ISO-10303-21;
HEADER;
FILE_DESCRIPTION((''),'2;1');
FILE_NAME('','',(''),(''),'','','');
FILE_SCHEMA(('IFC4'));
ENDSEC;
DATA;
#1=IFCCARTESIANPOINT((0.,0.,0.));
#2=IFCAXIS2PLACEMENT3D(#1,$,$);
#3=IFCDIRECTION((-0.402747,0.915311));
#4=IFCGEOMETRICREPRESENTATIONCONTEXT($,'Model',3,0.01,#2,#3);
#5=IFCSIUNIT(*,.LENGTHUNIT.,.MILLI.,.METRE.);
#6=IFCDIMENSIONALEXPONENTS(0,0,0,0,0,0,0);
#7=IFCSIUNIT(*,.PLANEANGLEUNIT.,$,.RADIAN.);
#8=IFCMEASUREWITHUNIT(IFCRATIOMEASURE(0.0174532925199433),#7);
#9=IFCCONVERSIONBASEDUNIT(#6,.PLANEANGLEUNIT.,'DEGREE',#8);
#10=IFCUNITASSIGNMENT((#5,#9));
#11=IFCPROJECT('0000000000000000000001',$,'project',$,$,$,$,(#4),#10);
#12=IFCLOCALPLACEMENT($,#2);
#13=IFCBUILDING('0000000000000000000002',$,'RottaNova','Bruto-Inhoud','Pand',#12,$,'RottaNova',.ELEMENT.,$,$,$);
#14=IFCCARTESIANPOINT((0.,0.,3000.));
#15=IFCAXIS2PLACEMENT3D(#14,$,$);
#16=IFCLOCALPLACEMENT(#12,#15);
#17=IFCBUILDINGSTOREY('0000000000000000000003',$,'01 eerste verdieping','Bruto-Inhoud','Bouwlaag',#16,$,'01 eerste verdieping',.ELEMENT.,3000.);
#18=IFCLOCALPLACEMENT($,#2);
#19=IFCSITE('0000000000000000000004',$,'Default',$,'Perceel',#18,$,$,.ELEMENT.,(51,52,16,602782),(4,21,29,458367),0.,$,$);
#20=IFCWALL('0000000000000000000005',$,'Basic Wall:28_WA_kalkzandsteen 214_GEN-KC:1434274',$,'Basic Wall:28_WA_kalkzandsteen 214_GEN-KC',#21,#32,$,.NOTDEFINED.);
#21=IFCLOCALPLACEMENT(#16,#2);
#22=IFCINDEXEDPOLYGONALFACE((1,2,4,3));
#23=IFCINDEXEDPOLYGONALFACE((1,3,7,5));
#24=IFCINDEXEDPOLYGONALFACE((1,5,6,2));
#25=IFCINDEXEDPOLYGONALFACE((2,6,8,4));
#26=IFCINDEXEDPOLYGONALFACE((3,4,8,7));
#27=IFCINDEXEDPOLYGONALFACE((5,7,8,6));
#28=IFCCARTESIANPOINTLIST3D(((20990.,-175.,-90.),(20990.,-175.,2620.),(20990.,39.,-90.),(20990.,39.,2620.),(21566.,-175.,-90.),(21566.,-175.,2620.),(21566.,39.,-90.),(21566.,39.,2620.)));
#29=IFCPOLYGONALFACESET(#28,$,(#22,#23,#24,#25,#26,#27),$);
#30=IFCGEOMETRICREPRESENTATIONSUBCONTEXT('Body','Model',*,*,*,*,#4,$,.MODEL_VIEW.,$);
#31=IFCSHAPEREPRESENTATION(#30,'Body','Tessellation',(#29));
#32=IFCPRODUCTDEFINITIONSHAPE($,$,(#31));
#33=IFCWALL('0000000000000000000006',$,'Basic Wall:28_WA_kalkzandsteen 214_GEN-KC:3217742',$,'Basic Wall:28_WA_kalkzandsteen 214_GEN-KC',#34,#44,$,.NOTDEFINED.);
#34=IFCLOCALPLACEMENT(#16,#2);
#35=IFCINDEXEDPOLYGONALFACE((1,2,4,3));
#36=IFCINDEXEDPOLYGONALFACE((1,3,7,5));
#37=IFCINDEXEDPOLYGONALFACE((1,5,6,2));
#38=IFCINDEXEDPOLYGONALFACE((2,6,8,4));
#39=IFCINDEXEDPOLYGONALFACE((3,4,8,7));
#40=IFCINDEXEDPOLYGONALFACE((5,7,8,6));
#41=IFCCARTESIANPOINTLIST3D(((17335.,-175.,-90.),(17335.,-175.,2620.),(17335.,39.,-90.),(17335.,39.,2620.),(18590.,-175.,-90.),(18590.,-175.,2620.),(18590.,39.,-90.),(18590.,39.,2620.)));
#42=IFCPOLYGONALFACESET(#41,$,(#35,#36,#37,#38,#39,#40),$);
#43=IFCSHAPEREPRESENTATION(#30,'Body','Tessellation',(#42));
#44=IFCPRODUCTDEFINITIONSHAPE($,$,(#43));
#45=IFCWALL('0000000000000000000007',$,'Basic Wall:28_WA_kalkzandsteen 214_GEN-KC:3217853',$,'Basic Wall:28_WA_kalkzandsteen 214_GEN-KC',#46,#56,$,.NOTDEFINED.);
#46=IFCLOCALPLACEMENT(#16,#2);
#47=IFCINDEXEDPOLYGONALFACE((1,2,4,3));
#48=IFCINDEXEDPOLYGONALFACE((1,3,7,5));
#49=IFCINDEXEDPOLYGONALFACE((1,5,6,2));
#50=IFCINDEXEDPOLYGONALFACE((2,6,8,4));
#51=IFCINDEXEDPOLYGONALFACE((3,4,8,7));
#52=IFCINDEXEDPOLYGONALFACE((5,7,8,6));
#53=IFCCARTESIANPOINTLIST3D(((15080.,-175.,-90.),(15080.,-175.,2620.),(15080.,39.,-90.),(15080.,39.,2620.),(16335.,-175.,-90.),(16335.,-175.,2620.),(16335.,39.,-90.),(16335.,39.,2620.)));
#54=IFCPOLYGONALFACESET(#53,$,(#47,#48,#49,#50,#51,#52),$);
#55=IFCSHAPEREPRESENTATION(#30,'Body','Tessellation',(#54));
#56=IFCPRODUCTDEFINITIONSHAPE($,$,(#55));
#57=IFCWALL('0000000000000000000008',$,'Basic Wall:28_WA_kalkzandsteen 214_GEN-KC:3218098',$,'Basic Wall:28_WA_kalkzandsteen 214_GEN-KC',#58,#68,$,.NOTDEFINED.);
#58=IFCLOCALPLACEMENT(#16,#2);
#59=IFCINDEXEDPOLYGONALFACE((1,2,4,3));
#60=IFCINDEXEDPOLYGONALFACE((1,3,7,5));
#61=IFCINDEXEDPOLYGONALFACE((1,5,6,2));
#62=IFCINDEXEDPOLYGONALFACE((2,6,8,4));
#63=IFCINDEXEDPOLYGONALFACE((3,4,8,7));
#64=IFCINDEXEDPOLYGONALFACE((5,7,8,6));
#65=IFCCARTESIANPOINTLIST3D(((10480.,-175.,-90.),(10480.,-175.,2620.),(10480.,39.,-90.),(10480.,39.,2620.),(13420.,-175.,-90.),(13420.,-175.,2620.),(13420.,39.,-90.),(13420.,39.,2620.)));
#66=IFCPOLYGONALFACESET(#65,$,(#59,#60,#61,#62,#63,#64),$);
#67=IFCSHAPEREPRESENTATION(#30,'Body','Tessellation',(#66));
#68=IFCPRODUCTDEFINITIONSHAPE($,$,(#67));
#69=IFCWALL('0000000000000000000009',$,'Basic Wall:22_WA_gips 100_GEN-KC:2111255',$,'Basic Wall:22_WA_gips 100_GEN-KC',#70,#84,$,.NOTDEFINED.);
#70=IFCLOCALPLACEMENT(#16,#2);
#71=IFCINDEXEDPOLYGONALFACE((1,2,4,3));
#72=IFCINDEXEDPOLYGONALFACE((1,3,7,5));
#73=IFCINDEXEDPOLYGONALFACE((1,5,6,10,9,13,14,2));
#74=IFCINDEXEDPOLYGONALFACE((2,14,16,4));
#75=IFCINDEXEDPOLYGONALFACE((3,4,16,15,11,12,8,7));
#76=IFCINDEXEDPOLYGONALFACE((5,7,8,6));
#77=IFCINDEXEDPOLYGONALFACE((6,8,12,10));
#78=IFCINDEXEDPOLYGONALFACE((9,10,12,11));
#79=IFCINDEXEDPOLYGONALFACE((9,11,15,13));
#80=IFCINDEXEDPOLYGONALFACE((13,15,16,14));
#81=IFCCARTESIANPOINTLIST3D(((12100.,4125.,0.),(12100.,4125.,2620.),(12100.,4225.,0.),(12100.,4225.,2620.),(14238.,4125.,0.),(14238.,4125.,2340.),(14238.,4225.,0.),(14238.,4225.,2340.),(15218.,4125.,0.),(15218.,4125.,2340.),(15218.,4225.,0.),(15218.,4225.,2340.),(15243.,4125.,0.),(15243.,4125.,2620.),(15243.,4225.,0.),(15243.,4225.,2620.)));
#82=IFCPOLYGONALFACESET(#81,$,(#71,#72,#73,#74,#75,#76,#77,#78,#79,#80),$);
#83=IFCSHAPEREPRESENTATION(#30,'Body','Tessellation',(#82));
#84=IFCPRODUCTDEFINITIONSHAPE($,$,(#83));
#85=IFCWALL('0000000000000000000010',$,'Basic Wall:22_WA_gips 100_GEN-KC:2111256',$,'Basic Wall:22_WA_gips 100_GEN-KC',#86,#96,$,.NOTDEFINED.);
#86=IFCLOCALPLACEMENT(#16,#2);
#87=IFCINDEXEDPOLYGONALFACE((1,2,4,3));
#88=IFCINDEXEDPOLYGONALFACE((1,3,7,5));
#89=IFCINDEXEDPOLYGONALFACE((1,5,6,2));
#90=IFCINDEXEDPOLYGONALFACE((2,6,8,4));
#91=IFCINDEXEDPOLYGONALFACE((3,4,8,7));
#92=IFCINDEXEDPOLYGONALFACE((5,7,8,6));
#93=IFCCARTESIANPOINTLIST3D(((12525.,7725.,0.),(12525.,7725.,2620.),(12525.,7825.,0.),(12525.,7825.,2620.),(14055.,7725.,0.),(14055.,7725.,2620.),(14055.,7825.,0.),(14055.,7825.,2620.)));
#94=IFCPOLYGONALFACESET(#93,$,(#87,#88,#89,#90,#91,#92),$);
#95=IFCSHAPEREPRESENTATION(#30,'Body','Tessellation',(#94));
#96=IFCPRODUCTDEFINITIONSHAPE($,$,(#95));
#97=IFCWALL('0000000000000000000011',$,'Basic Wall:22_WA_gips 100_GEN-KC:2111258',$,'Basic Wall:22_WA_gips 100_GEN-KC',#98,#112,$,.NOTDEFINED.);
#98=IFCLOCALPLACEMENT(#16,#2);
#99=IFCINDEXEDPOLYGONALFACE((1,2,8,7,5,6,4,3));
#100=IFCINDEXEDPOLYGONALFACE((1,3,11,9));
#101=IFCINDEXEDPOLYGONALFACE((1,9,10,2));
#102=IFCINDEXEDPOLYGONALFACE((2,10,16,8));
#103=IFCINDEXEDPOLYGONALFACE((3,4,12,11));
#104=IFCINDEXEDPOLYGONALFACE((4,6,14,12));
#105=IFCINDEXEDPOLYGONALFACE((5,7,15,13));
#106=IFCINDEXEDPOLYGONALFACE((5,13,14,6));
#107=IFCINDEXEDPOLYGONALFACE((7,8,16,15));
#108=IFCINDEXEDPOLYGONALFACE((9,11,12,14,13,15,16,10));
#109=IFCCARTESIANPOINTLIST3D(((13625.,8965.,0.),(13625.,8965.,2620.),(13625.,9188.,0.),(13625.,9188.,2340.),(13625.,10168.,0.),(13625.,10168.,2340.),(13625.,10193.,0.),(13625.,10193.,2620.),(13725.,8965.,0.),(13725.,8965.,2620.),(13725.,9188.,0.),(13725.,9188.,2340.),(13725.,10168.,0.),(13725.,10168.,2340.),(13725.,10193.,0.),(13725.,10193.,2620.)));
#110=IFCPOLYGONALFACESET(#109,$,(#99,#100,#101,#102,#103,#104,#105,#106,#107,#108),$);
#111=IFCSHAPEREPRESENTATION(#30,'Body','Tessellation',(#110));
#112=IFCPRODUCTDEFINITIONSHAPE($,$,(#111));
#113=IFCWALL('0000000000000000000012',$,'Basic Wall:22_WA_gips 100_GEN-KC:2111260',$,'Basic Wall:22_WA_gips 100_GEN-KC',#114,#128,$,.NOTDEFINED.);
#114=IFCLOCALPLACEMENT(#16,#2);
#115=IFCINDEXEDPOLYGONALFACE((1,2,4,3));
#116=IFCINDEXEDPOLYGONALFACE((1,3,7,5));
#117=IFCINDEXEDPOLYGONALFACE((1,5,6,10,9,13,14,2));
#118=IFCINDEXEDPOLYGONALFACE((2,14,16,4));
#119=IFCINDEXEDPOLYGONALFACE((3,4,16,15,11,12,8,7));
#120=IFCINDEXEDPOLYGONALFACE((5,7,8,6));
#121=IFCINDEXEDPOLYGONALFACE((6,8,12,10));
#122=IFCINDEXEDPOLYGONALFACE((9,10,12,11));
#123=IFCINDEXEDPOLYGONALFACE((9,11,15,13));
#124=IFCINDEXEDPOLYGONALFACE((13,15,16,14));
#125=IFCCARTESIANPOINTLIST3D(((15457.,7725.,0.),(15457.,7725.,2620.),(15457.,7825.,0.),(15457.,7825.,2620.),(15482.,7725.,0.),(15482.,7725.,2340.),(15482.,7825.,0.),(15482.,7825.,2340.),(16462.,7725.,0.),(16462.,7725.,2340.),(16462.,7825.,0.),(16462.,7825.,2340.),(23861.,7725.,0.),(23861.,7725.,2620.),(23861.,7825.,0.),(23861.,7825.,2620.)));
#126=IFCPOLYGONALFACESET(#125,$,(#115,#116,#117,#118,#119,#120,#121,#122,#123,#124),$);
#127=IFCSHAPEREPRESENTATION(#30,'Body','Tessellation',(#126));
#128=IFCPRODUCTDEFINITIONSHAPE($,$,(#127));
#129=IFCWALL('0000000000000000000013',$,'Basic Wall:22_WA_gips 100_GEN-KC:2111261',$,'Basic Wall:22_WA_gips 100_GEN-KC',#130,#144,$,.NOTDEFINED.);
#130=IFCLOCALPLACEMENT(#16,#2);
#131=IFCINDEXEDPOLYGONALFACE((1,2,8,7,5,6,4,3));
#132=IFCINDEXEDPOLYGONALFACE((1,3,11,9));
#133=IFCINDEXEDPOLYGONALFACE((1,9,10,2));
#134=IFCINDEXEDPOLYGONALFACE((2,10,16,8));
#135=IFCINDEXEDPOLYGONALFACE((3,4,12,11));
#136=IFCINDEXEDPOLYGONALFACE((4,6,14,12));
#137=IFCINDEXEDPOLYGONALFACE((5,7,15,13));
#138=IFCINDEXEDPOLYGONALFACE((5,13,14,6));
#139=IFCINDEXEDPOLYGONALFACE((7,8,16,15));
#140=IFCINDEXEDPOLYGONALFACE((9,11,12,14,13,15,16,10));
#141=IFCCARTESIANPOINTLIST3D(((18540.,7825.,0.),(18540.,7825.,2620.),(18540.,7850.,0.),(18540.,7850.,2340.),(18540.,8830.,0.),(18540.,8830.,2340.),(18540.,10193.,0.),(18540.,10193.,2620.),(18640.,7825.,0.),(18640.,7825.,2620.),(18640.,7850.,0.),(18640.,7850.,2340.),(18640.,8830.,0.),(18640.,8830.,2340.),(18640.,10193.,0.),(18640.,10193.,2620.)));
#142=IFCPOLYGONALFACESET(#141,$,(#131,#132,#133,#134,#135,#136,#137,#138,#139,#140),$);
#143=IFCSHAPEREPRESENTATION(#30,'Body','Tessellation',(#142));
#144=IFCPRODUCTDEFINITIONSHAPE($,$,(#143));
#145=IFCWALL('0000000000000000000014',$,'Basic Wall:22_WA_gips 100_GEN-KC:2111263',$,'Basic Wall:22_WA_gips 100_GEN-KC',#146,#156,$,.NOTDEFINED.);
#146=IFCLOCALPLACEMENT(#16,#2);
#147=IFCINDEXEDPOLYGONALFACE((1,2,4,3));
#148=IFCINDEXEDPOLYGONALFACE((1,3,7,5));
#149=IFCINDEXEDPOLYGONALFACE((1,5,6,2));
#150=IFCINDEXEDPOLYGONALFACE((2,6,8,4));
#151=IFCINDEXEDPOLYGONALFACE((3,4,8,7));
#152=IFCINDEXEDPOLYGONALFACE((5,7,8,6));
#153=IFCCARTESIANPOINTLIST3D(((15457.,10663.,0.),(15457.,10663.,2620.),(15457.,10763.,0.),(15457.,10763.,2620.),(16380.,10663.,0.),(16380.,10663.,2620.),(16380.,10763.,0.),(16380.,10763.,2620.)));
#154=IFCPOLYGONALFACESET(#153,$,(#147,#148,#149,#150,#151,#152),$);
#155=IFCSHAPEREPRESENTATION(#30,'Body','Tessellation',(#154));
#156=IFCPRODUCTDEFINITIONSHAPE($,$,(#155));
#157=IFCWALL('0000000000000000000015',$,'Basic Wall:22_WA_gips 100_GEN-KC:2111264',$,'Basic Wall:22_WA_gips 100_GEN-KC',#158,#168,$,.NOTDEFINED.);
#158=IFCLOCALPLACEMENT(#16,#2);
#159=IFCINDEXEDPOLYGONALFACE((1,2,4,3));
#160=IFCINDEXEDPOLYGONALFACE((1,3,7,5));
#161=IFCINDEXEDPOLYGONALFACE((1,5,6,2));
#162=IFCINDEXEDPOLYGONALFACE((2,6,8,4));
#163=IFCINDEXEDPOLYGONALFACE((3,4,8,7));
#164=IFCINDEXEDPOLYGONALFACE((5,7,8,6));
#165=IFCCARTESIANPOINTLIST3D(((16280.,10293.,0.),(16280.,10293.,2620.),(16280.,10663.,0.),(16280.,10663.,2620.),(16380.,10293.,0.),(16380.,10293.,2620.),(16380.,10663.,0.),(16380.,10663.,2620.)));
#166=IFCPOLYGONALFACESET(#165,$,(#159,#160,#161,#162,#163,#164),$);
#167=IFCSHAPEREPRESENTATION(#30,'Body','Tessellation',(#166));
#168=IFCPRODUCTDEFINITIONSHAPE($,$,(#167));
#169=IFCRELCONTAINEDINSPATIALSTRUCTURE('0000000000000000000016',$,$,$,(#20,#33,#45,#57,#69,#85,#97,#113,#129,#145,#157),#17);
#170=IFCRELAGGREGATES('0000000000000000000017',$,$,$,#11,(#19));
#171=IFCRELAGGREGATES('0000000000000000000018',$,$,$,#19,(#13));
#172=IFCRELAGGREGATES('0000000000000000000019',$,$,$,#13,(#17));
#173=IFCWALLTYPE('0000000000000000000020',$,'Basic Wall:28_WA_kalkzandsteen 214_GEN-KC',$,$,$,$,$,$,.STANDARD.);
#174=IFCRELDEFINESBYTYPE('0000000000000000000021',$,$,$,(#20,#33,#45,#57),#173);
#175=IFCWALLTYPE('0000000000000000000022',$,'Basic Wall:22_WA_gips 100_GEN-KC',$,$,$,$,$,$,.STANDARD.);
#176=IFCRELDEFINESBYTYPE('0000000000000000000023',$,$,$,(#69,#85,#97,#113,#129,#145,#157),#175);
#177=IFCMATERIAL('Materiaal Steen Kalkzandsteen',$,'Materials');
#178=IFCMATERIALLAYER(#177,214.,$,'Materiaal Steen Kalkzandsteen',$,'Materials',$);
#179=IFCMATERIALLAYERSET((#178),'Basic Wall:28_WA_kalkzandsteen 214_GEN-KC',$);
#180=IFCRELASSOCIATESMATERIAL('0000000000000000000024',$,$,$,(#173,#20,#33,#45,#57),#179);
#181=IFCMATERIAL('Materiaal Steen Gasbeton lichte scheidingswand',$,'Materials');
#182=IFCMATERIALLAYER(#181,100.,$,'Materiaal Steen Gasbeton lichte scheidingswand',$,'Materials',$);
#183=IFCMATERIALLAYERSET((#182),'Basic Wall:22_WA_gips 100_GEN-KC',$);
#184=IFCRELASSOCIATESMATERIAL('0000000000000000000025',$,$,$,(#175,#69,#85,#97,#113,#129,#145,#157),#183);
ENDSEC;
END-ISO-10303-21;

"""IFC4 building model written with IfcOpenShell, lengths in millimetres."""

from ifc_helpers import new_model, entity, si_unit, converted_unit, direction, frame, frame_2d, origin, place, context, subcontext, project, spatial, rectangle, extrude, material, layer, layer_set, type_object, element, save


model = new_model("IFC4")

# Units and contexts
model_context = context("Model", 3, precision=0.01, world=origin(), true_north=direction((-0.402747, 0.915311)))
body_context = subcontext(model_context, "Body", "Model", "MODEL_VIEW")
ifc_project = project(units=[si_unit("LENGTHUNIT", "METRE", prefix="MILLI"), converted_unit("PLANEANGLEUNIT", "DEGREE", entity("IfcRatioMeasure", 0.0174532925199433), si_unit("PLANEANGLEUNIT", "RADIAN"), dimensions=[0, 0, 0, 0, 0, 0, 0])], contexts=[model_context])

# Site, building, storey
site_placement = place(None, origin())
site = spatial("IfcSite", under=ifc_project, at=site_placement, Name="Default", ObjectType="Perceel", CompositionType="ELEMENT", RefLatitude=(51, 52, 16, 602782), RefLongitude=(4, 21, 29, 458367), RefElevation=0.0)
building_placement = place(None, origin())
building = spatial("IfcBuilding", under=site, at=building_placement, Name="RottaNova", Description="Bruto-Inhoud", ObjectType="Pand", LongName="RottaNova", CompositionType="ELEMENT")
storey_placement = place(building_placement, frame((0.0, 0.0, 3000.0)))
storey = spatial("IfcBuildingStorey", under=building, at=storey_placement, Name="01 eerste verdieping", Description="Bruto-Inhoud", ObjectType="Bouwlaag", LongName="01 eerste verdieping", CompositionType="ELEMENT", Elevation=3000.0)

# Walls
ifc_material_1 = material(Name="Materiaal Steen Kalkzandsteen", Category="Materials")
ifc_layer_1 = layer(ifc_material_1, 214.0, Name="Materiaal Steen Kalkzandsteen", Category="Materials")
ifc_layer_set_1 = layer_set([ifc_layer_1], Name="Basic Wall:28_WA_kalkzandsteen 214_GEN-KC")
wall_type_1 = type_object("IfcWallType", Name="Basic Wall:28_WA_kalkzandsteen 214_GEN-KC", PredefinedType="STANDARD", material=ifc_layer_set_1)
wall_1_placement = place(storey_placement, frame((21566.0, -68.0, -90.0), z_axis=(0.0, 0.0, 1.0), x_axis=(-1.0, 0.0, 0.0)))
element("IfcWall", 1, at=wall_1_placement, inside=storey, type_object=wall_type_1, material=ifc_layer_set_1, Name="Basic Wall:28_WA_kalkzandsteen 214_GEN-KC:1434274", ObjectType="Basic Wall:28_WA_kalkzandsteen 214_GEN-KC", PredefinedType="NOTDEFINED", context=body_context, shape_type="SweptSolid", body=[
    extrude(rectangle(XDim=576.0, YDim=214.0, at=frame_2d((288.0, 0.0), x_axis=(-1.0, 0.0))), origin(), (0.0, 0.0, 1.0), 2710.0),
])
wall_2_placement = place(storey_placement, frame((18590.0, -68.0, -90.0), z_axis=(0.0, 0.0, 1.0), x_axis=(-1.0, 0.0, 0.0)))
element("IfcWall", 2, at=wall_2_placement, inside=storey, type_object=wall_type_1, material=ifc_layer_set_1, Name="Basic Wall:28_WA_kalkzandsteen 214_GEN-KC:3217742", ObjectType="Basic Wall:28_WA_kalkzandsteen 214_GEN-KC", PredefinedType="NOTDEFINED", context=body_context, shape_type="SweptSolid", body=[
    extrude(rectangle(XDim=1255.0, YDim=214.0, at=frame_2d((627.5, 0.0), x_axis=(-1.0, 0.0))), origin(), (0.0, 0.0, 1.0), 2710.0),
])
wall_3_placement = place(storey_placement, frame((16335.0, -68.0, -90.0), z_axis=(0.0, 0.0, 1.0), x_axis=(-1.0, 0.0, 0.0)))
element("IfcWall", 3, at=wall_3_placement, inside=storey, type_object=wall_type_1, material=ifc_layer_set_1, Name="Basic Wall:28_WA_kalkzandsteen 214_GEN-KC:3217853", ObjectType="Basic Wall:28_WA_kalkzandsteen 214_GEN-KC", PredefinedType="NOTDEFINED", context=body_context, shape_type="SweptSolid", body=[
    extrude(rectangle(XDim=1255.0, YDim=214.0, at=frame_2d((627.5, 0.0), x_axis=(-1.0, 0.0))), origin(), (0.0, 0.0, 1.0), 2710.0),
])
wall_4_placement = place(storey_placement, frame((13420.0, -68.0, -90.0), z_axis=(0.0, 0.0, 1.0), x_axis=(-1.0, 0.0, 0.0)))
element("IfcWall", 4, at=wall_4_placement, inside=storey, type_object=wall_type_1, material=ifc_layer_set_1, Name="Basic Wall:28_WA_kalkzandsteen 214_GEN-KC:3218098", ObjectType="Basic Wall:28_WA_kalkzandsteen 214_GEN-KC", PredefinedType="NOTDEFINED", context=body_context, shape_type="SweptSolid", body=[
    extrude(rectangle(XDim=2940.0, YDim=214.0, at=frame_2d((1470.0, 0.0), x_axis=(-1.0, 0.0))), origin(), (0.0, 0.0, 1.0), 2710.0),
])

# Wall, opening
ifc_material_2 = material(Name="Materiaal Steen Gasbeton lichte scheidingswand", Category="Materials")
ifc_layer_2 = layer(ifc_material_2, 100.0, Name="Materiaal Steen Gasbeton lichte scheidingswand", Category="Materials")
ifc_layer_set_2 = layer_set([ifc_layer_2], Name="Basic Wall:22_WA_gips 100_GEN-KC")
wall_type_2 = type_object("IfcWallType", Name="Basic Wall:22_WA_gips 100_GEN-KC", PredefinedType="STANDARD", material=ifc_layer_set_2)
wall_5_placement = place(storey_placement, frame((15243.0, 4175.0, 0.0), z_axis=(0.0, 0.0, 1.0), x_axis=(-1.0, 0.0, 0.0)))
wall_5 = element("IfcWall", 5, at=wall_5_placement, inside=storey, type_object=wall_type_2, material=ifc_layer_set_2, Name="Basic Wall:22_WA_gips 100_GEN-KC:2111255", ObjectType="Basic Wall:22_WA_gips 100_GEN-KC", PredefinedType="NOTDEFINED", context=body_context, shape_type="SweptSolid", body=[
    extrude(rectangle(XDim=3143.0, YDim=100.0, at=frame_2d((1571.5, 0.0), x_axis=(-1.0, 0.0))), origin(), (0.0, 0.0, 1.0), 2620.0),
])
opening_1_placement = place(wall_5_placement, frame((25.0, -50.0, -90.0)))
element("IfcOpeningElement", 6, at=opening_1_placement, cuts=wall_5, PredefinedType="OPENING", context=body_context, shape_type="SweptSolid", body=[
    extrude(rectangle(XDim=2430.0, YDim=980.0, at=frame_2d((1215.0, 490.0), x_axis=(1.0, 0.0))), frame((0.0, 0.0, 0.0), z_axis=(0.0, 1.0, 0.0), x_axis=(0.0, 0.0, 1.0)), (0.0, 0.0, 1.0), 100.0),
])

# Wall
wall_6_placement = place(storey_placement, frame((14055.0, 7775.0, 0.0), z_axis=(0.0, 0.0, 1.0), x_axis=(-1.0, 0.0, 0.0)))
element("IfcWall", 7, at=wall_6_placement, inside=storey, type_object=wall_type_2, material=ifc_layer_set_2, Name="Basic Wall:22_WA_gips 100_GEN-KC:2111256", ObjectType="Basic Wall:22_WA_gips 100_GEN-KC", PredefinedType="NOTDEFINED", context=body_context, shape_type="SweptSolid", body=[
    extrude(rectangle(XDim=1530.0, YDim=100.0, at=frame_2d((765.0, 0.0), x_axis=(-1.0, 0.0))), origin(), (0.0, 0.0, 1.0), 2620.0),
])

# Walls, openings
wall_7_placement = place(storey_placement, frame((13675.0, 8965.0, 0.0), z_axis=(0.0, 0.0, 1.0), x_axis=(0.0, 1.0, 0.0)))
wall_7 = element("IfcWall", 8, at=wall_7_placement, inside=storey, type_object=wall_type_2, material=ifc_layer_set_2, Name="Basic Wall:22_WA_gips 100_GEN-KC:2111258", ObjectType="Basic Wall:22_WA_gips 100_GEN-KC", PredefinedType="NOTDEFINED", context=body_context, shape_type="SweptSolid", body=[
    extrude(rectangle(XDim=1228.0, YDim=100.0, at=frame_2d((614.0, 0.0), x_axis=(1.0, 0.0))), origin(), (0.0, 0.0, 1.0), 2620.0),
])
opening_2_placement = place(wall_7_placement, frame((1203.0, 50.0, -90.0)))
element("IfcOpeningElement", 9, at=opening_2_placement, cuts=wall_7, PredefinedType="OPENING", context=body_context, shape_type="SweptSolid", body=[
    extrude(rectangle(XDim=2430.0, YDim=980.0, at=frame_2d((1215.0, 490.0), x_axis=(1.0, 0.0))), frame((0.0, 0.0, 0.0), z_axis=(0.0, -1.0, 0.0), x_axis=(0.0, 0.0, 1.0)), (0.0, 0.0, 1.0), 100.0),
])
wall_8_placement = place(storey_placement, frame((23861.0, 7775.0, 0.0), z_axis=(0.0, 0.0, 1.0), x_axis=(-1.0, 0.0, 0.0)))
wall_8 = element("IfcWall", 10, at=wall_8_placement, inside=storey, type_object=wall_type_2, material=ifc_layer_set_2, Name="Basic Wall:22_WA_gips 100_GEN-KC:2111260", ObjectType="Basic Wall:22_WA_gips 100_GEN-KC", PredefinedType="NOTDEFINED", context=body_context, shape_type="SweptSolid", body=[
    extrude(rectangle(XDim=8404.0, YDim=100.0, at=frame_2d((4202.0, 0.0), x_axis=(1.0, 0.0))), origin(), (0.0, 0.0, 1.0), 2620.0),
])
opening_3_placement = place(wall_8_placement, frame((7399.0, -50.0, -90.0)))
element("IfcOpeningElement", 11, at=opening_3_placement, cuts=wall_8, PredefinedType="OPENING", context=body_context, shape_type="SweptSolid", body=[
    extrude(rectangle(XDim=2430.0, YDim=980.0, at=frame_2d((1215.0, 490.0), x_axis=(1.0, 0.0))), frame((0.0, 0.0, 0.0), z_axis=(0.0, 1.0, 0.0), x_axis=(0.0, 0.0, 1.0)), (0.0, 0.0, 1.0), 100.0),
])
wall_9_placement = place(storey_placement, frame((18590.0, 10193.0, 0.0), z_axis=(0.0, 0.0, 1.0), x_axis=(0.0, -1.0, 0.0)))
wall_9 = element("IfcWall", 12, at=wall_9_placement, inside=storey, type_object=wall_type_2, material=ifc_layer_set_2, Name="Basic Wall:22_WA_gips 100_GEN-KC:2111261", ObjectType="Basic Wall:22_WA_gips 100_GEN-KC", PredefinedType="NOTDEFINED", context=body_context, shape_type="SweptSolid", body=[
    extrude(rectangle(XDim=2368.0, YDim=100.0, at=frame_2d((1184.0, 0.0), x_axis=(1.0, 0.0))), origin(), (0.0, 0.0, 1.0), 2620.0),
])
opening_4_placement = place(wall_9_placement, frame((1363.0, -50.0, -90.0)))
element("IfcOpeningElement", 13, at=opening_4_placement, cuts=wall_9, PredefinedType="OPENING", context=body_context, shape_type="SweptSolid", body=[
    extrude(rectangle(XDim=2430.0, YDim=980.0, at=frame_2d((1215.0, 490.0), x_axis=(1.0, 0.0))), frame((0.0, 0.0, 0.0), z_axis=(0.0, 1.0, 0.0), x_axis=(0.0, 0.0, 1.0)), (0.0, 0.0, 1.0), 100.0),
])

# Walls
wall_10_placement = place(storey_placement, frame((16380.0, 10713.0, 0.0), z_axis=(0.0, 0.0, 1.0), x_axis=(-1.0, 0.0, 0.0)))
element("IfcWall", 14, at=wall_10_placement, inside=storey, type_object=wall_type_2, material=ifc_layer_set_2, Name="Basic Wall:22_WA_gips 100_GEN-KC:2111263", ObjectType="Basic Wall:22_WA_gips 100_GEN-KC", PredefinedType="NOTDEFINED", context=body_context, shape_type="SweptSolid", body=[
    extrude(rectangle(XDim=923.0, YDim=100.0, at=frame_2d((461.5, 0.0), x_axis=(-1.0, 0.0))), origin(), (0.0, 0.0, 1.0), 2620.0),
])
wall_11_placement = place(storey_placement, frame((16330.0, 10663.0, 0.0), z_axis=(0.0, 0.0, 1.0), x_axis=(0.0, -1.0, 0.0)))
element("IfcWall", 15, at=wall_11_placement, inside=storey, type_object=wall_type_2, material=ifc_layer_set_2, Name="Basic Wall:22_WA_gips 100_GEN-KC:2111264", ObjectType="Basic Wall:22_WA_gips 100_GEN-KC", PredefinedType="NOTDEFINED", context=body_context, shape_type="SweptSolid", body=[
    extrude(rectangle(XDim=370.0, YDim=100.0, at=frame_2d((185.0, 0.0), x_axis=(-1.0, 0.0))), origin(), (0.0, 0.0, 1.0), 2620.0),
])

save(model, "model.ifc")
